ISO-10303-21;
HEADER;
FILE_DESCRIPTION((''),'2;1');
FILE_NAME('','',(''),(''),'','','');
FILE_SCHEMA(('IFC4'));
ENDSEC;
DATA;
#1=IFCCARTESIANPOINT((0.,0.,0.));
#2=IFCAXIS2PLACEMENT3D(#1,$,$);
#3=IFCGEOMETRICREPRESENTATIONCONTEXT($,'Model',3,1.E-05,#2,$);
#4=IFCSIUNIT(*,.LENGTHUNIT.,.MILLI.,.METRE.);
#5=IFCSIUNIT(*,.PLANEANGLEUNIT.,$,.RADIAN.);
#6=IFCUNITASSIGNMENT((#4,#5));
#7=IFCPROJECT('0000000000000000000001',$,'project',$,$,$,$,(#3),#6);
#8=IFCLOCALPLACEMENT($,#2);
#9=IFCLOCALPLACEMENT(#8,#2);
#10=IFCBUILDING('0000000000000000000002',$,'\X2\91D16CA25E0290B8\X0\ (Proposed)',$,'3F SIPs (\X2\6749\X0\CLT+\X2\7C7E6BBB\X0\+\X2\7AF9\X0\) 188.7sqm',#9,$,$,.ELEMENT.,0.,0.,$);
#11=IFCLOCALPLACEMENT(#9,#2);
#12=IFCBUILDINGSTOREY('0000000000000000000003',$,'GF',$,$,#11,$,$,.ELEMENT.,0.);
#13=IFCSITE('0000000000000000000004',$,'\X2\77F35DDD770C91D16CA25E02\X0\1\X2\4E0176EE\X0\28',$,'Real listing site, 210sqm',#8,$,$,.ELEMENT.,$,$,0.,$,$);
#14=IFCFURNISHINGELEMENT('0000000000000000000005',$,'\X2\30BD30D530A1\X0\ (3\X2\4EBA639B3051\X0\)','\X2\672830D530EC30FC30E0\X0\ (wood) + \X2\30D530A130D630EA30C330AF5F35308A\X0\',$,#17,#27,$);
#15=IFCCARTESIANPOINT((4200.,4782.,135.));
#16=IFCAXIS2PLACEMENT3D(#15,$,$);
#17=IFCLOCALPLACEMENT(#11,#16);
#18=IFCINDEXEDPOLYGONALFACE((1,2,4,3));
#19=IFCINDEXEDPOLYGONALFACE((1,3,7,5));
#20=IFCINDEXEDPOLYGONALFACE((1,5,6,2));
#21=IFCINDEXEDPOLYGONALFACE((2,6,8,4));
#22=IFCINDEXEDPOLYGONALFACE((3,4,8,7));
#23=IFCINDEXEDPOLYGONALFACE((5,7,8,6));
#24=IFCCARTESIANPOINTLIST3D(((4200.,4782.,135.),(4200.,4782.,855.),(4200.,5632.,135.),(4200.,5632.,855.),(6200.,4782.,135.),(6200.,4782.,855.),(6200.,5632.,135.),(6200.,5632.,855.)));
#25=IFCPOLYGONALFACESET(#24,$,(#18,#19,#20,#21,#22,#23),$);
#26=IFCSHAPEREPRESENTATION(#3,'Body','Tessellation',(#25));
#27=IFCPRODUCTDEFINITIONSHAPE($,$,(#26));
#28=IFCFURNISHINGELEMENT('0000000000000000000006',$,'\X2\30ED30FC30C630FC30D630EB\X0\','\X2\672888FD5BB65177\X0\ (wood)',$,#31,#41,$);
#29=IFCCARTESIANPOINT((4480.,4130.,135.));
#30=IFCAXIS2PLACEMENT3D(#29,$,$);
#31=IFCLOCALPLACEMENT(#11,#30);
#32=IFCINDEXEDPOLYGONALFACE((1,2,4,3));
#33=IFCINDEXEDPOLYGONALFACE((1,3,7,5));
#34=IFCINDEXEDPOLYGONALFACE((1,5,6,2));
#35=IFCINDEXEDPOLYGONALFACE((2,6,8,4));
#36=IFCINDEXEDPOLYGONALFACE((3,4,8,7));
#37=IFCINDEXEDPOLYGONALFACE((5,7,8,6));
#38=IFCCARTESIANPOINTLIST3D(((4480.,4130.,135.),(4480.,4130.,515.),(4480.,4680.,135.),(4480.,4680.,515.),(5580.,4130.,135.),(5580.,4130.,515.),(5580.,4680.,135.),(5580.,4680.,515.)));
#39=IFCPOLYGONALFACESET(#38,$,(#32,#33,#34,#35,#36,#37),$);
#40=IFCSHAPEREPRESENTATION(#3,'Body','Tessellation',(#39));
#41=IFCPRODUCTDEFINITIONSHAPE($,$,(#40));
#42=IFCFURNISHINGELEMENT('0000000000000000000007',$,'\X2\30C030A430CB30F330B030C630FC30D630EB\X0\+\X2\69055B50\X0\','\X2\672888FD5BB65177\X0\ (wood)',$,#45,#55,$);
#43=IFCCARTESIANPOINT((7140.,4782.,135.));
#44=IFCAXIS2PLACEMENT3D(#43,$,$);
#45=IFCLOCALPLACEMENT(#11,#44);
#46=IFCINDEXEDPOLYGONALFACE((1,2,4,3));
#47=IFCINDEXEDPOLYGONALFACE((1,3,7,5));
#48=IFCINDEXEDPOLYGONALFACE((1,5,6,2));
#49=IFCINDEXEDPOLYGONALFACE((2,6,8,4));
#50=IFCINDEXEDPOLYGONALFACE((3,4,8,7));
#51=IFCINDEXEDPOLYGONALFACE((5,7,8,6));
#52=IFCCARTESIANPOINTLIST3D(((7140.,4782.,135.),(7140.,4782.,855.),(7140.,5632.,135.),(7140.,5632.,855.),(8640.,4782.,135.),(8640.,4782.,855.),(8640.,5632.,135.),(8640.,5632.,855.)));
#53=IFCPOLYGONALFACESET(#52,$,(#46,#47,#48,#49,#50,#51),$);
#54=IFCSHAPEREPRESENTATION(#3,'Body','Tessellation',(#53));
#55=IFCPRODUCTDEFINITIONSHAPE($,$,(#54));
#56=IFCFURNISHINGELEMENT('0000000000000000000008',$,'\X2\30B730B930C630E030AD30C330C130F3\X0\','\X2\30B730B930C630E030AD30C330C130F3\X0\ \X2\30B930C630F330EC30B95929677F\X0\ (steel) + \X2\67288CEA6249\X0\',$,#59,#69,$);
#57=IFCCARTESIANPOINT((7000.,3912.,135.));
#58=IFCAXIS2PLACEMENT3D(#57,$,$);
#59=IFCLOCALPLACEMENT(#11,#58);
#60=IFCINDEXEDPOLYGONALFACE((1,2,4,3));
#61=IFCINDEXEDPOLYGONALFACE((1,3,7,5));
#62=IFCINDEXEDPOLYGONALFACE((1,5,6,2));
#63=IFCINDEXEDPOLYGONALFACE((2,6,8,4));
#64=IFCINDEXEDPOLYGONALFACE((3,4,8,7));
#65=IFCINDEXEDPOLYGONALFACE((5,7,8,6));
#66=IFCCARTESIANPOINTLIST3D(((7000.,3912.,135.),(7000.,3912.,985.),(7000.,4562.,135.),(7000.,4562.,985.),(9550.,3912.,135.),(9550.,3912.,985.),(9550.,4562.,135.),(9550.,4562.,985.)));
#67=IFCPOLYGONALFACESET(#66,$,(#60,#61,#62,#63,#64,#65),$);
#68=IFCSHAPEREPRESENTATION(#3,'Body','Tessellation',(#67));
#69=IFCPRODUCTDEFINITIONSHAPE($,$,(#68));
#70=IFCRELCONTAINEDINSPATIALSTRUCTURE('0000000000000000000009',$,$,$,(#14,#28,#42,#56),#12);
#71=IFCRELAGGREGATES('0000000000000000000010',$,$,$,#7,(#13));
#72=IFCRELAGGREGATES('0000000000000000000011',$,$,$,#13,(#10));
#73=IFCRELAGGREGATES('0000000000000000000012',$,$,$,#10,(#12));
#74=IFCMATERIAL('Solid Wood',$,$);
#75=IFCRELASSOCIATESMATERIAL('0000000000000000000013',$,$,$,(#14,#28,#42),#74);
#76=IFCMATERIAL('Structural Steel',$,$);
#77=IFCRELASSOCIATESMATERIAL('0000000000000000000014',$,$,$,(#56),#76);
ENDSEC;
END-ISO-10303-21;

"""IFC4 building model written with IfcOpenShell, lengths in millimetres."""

from ifc_helpers import new_model, si_unit, frame, frame_2d, origin, place, context, project, spatial, rectangle, extrude, material, element, save


model = new_model("IFC4")

# Units and contexts
model_context = context("Model", 3, precision=1e-05, world=origin())
ifc_project = project(units=[si_unit("LENGTHUNIT", "METRE", prefix="MILLI"), si_unit("PLANEANGLEUNIT", "RADIAN")], contexts=[model_context])

# Site, building, storey
site_placement = place(None, origin())
site = spatial("IfcSite", under=ifc_project, at=site_placement, Name="石川県金沢市1丁目28", ObjectType="Real listing site, 210sqm", CompositionType="ELEMENT", RefElevation=0.0)
building_placement = place(site_placement, origin())
building = spatial("IfcBuilding", under=site, at=building_placement, Name="金沢市邸 (Proposed)", ObjectType="3F SIPs (杉CLT+籾殻+竹) 188.7sqm", CompositionType="ELEMENT", ElevationOfRefHeight=0.0, ElevationOfTerrain=0.0)
storey_placement = place(building_placement, origin())
storey = spatial("IfcBuildingStorey", under=building, at=storey_placement, Name="GF", CompositionType="ELEMENT", Elevation=0.0)

# Shared definitions
ifc_material_1 = material(Name="Solid Wood")

# Furnishing elements
furnishing_1_placement = place(storey_placement, frame((4200.0, 4782.0, 135.0)))
element("IfcFurnishingElement", 1, at=furnishing_1_placement, inside=storey, material=ifc_material_1, Name="ソファ (3人掛け)", Description="木フレーム (wood) + ファブリック張り", context=model_context, shape_type="SweptSolid", body=[
    extrude(rectangle(XDim=2000.0, YDim=850.0, at=frame_2d((1000.0, 425.0))), frame((4200.0, 4782.0, 135.0)), (0.0, 0.0, 1.0), 720.0),
])
furnishing_2_placement = place(storey_placement, frame((4480.0, 4130.0, 135.0)))
element("IfcFurnishingElement", 2, at=furnishing_2_placement, inside=storey, material=ifc_material_1, Name="ローテーブル", Description="木製家具 (wood)", context=model_context, shape_type="SweptSolid", body=[
    extrude(rectangle(XDim=1100.0, YDim=550.0, at=frame_2d((550.0, 275.0))), frame((4480.0, 4130.0, 135.0)), (0.0, 0.0, 1.0), 380.0),
])
furnishing_3_placement = place(storey_placement, frame((7140.0, 4782.0, 135.0)))
element("IfcFurnishingElement", 3, at=furnishing_3_placement, inside=storey, material=ifc_material_1, Name="ダイニングテーブル+椅子", Description="木製家具 (wood)", context=model_context, shape_type="SweptSolid", body=[
    extrude(rectangle(XDim=1500.0, YDim=850.0, at=frame_2d((750.0, 425.0))), frame((7140.0, 4782.0, 135.0)), (0.0, 0.0, 1.0), 720.0),
])
ifc_material_2 = material(Name="Structural Steel")
furnishing_4_placement = place(storey_placement, frame((7000.0, 3912.0, 135.0)))
element("IfcFurnishingElement", 4, at=furnishing_4_placement, inside=storey, material=ifc_material_2, Name="システムキッチン", Description="システムキッチン ステンレス天板 (steel) + 木質扉", context=model_context, shape_type="SweptSolid", body=[
    extrude(rectangle(XDim=2550.0, YDim=650.0, at=frame_2d((1275.0, 325.0))), frame((7000.0, 3912.0, 135.0)), (0.0, 0.0, 1.0), 850.0),
])

save(model, "model.ifc")
